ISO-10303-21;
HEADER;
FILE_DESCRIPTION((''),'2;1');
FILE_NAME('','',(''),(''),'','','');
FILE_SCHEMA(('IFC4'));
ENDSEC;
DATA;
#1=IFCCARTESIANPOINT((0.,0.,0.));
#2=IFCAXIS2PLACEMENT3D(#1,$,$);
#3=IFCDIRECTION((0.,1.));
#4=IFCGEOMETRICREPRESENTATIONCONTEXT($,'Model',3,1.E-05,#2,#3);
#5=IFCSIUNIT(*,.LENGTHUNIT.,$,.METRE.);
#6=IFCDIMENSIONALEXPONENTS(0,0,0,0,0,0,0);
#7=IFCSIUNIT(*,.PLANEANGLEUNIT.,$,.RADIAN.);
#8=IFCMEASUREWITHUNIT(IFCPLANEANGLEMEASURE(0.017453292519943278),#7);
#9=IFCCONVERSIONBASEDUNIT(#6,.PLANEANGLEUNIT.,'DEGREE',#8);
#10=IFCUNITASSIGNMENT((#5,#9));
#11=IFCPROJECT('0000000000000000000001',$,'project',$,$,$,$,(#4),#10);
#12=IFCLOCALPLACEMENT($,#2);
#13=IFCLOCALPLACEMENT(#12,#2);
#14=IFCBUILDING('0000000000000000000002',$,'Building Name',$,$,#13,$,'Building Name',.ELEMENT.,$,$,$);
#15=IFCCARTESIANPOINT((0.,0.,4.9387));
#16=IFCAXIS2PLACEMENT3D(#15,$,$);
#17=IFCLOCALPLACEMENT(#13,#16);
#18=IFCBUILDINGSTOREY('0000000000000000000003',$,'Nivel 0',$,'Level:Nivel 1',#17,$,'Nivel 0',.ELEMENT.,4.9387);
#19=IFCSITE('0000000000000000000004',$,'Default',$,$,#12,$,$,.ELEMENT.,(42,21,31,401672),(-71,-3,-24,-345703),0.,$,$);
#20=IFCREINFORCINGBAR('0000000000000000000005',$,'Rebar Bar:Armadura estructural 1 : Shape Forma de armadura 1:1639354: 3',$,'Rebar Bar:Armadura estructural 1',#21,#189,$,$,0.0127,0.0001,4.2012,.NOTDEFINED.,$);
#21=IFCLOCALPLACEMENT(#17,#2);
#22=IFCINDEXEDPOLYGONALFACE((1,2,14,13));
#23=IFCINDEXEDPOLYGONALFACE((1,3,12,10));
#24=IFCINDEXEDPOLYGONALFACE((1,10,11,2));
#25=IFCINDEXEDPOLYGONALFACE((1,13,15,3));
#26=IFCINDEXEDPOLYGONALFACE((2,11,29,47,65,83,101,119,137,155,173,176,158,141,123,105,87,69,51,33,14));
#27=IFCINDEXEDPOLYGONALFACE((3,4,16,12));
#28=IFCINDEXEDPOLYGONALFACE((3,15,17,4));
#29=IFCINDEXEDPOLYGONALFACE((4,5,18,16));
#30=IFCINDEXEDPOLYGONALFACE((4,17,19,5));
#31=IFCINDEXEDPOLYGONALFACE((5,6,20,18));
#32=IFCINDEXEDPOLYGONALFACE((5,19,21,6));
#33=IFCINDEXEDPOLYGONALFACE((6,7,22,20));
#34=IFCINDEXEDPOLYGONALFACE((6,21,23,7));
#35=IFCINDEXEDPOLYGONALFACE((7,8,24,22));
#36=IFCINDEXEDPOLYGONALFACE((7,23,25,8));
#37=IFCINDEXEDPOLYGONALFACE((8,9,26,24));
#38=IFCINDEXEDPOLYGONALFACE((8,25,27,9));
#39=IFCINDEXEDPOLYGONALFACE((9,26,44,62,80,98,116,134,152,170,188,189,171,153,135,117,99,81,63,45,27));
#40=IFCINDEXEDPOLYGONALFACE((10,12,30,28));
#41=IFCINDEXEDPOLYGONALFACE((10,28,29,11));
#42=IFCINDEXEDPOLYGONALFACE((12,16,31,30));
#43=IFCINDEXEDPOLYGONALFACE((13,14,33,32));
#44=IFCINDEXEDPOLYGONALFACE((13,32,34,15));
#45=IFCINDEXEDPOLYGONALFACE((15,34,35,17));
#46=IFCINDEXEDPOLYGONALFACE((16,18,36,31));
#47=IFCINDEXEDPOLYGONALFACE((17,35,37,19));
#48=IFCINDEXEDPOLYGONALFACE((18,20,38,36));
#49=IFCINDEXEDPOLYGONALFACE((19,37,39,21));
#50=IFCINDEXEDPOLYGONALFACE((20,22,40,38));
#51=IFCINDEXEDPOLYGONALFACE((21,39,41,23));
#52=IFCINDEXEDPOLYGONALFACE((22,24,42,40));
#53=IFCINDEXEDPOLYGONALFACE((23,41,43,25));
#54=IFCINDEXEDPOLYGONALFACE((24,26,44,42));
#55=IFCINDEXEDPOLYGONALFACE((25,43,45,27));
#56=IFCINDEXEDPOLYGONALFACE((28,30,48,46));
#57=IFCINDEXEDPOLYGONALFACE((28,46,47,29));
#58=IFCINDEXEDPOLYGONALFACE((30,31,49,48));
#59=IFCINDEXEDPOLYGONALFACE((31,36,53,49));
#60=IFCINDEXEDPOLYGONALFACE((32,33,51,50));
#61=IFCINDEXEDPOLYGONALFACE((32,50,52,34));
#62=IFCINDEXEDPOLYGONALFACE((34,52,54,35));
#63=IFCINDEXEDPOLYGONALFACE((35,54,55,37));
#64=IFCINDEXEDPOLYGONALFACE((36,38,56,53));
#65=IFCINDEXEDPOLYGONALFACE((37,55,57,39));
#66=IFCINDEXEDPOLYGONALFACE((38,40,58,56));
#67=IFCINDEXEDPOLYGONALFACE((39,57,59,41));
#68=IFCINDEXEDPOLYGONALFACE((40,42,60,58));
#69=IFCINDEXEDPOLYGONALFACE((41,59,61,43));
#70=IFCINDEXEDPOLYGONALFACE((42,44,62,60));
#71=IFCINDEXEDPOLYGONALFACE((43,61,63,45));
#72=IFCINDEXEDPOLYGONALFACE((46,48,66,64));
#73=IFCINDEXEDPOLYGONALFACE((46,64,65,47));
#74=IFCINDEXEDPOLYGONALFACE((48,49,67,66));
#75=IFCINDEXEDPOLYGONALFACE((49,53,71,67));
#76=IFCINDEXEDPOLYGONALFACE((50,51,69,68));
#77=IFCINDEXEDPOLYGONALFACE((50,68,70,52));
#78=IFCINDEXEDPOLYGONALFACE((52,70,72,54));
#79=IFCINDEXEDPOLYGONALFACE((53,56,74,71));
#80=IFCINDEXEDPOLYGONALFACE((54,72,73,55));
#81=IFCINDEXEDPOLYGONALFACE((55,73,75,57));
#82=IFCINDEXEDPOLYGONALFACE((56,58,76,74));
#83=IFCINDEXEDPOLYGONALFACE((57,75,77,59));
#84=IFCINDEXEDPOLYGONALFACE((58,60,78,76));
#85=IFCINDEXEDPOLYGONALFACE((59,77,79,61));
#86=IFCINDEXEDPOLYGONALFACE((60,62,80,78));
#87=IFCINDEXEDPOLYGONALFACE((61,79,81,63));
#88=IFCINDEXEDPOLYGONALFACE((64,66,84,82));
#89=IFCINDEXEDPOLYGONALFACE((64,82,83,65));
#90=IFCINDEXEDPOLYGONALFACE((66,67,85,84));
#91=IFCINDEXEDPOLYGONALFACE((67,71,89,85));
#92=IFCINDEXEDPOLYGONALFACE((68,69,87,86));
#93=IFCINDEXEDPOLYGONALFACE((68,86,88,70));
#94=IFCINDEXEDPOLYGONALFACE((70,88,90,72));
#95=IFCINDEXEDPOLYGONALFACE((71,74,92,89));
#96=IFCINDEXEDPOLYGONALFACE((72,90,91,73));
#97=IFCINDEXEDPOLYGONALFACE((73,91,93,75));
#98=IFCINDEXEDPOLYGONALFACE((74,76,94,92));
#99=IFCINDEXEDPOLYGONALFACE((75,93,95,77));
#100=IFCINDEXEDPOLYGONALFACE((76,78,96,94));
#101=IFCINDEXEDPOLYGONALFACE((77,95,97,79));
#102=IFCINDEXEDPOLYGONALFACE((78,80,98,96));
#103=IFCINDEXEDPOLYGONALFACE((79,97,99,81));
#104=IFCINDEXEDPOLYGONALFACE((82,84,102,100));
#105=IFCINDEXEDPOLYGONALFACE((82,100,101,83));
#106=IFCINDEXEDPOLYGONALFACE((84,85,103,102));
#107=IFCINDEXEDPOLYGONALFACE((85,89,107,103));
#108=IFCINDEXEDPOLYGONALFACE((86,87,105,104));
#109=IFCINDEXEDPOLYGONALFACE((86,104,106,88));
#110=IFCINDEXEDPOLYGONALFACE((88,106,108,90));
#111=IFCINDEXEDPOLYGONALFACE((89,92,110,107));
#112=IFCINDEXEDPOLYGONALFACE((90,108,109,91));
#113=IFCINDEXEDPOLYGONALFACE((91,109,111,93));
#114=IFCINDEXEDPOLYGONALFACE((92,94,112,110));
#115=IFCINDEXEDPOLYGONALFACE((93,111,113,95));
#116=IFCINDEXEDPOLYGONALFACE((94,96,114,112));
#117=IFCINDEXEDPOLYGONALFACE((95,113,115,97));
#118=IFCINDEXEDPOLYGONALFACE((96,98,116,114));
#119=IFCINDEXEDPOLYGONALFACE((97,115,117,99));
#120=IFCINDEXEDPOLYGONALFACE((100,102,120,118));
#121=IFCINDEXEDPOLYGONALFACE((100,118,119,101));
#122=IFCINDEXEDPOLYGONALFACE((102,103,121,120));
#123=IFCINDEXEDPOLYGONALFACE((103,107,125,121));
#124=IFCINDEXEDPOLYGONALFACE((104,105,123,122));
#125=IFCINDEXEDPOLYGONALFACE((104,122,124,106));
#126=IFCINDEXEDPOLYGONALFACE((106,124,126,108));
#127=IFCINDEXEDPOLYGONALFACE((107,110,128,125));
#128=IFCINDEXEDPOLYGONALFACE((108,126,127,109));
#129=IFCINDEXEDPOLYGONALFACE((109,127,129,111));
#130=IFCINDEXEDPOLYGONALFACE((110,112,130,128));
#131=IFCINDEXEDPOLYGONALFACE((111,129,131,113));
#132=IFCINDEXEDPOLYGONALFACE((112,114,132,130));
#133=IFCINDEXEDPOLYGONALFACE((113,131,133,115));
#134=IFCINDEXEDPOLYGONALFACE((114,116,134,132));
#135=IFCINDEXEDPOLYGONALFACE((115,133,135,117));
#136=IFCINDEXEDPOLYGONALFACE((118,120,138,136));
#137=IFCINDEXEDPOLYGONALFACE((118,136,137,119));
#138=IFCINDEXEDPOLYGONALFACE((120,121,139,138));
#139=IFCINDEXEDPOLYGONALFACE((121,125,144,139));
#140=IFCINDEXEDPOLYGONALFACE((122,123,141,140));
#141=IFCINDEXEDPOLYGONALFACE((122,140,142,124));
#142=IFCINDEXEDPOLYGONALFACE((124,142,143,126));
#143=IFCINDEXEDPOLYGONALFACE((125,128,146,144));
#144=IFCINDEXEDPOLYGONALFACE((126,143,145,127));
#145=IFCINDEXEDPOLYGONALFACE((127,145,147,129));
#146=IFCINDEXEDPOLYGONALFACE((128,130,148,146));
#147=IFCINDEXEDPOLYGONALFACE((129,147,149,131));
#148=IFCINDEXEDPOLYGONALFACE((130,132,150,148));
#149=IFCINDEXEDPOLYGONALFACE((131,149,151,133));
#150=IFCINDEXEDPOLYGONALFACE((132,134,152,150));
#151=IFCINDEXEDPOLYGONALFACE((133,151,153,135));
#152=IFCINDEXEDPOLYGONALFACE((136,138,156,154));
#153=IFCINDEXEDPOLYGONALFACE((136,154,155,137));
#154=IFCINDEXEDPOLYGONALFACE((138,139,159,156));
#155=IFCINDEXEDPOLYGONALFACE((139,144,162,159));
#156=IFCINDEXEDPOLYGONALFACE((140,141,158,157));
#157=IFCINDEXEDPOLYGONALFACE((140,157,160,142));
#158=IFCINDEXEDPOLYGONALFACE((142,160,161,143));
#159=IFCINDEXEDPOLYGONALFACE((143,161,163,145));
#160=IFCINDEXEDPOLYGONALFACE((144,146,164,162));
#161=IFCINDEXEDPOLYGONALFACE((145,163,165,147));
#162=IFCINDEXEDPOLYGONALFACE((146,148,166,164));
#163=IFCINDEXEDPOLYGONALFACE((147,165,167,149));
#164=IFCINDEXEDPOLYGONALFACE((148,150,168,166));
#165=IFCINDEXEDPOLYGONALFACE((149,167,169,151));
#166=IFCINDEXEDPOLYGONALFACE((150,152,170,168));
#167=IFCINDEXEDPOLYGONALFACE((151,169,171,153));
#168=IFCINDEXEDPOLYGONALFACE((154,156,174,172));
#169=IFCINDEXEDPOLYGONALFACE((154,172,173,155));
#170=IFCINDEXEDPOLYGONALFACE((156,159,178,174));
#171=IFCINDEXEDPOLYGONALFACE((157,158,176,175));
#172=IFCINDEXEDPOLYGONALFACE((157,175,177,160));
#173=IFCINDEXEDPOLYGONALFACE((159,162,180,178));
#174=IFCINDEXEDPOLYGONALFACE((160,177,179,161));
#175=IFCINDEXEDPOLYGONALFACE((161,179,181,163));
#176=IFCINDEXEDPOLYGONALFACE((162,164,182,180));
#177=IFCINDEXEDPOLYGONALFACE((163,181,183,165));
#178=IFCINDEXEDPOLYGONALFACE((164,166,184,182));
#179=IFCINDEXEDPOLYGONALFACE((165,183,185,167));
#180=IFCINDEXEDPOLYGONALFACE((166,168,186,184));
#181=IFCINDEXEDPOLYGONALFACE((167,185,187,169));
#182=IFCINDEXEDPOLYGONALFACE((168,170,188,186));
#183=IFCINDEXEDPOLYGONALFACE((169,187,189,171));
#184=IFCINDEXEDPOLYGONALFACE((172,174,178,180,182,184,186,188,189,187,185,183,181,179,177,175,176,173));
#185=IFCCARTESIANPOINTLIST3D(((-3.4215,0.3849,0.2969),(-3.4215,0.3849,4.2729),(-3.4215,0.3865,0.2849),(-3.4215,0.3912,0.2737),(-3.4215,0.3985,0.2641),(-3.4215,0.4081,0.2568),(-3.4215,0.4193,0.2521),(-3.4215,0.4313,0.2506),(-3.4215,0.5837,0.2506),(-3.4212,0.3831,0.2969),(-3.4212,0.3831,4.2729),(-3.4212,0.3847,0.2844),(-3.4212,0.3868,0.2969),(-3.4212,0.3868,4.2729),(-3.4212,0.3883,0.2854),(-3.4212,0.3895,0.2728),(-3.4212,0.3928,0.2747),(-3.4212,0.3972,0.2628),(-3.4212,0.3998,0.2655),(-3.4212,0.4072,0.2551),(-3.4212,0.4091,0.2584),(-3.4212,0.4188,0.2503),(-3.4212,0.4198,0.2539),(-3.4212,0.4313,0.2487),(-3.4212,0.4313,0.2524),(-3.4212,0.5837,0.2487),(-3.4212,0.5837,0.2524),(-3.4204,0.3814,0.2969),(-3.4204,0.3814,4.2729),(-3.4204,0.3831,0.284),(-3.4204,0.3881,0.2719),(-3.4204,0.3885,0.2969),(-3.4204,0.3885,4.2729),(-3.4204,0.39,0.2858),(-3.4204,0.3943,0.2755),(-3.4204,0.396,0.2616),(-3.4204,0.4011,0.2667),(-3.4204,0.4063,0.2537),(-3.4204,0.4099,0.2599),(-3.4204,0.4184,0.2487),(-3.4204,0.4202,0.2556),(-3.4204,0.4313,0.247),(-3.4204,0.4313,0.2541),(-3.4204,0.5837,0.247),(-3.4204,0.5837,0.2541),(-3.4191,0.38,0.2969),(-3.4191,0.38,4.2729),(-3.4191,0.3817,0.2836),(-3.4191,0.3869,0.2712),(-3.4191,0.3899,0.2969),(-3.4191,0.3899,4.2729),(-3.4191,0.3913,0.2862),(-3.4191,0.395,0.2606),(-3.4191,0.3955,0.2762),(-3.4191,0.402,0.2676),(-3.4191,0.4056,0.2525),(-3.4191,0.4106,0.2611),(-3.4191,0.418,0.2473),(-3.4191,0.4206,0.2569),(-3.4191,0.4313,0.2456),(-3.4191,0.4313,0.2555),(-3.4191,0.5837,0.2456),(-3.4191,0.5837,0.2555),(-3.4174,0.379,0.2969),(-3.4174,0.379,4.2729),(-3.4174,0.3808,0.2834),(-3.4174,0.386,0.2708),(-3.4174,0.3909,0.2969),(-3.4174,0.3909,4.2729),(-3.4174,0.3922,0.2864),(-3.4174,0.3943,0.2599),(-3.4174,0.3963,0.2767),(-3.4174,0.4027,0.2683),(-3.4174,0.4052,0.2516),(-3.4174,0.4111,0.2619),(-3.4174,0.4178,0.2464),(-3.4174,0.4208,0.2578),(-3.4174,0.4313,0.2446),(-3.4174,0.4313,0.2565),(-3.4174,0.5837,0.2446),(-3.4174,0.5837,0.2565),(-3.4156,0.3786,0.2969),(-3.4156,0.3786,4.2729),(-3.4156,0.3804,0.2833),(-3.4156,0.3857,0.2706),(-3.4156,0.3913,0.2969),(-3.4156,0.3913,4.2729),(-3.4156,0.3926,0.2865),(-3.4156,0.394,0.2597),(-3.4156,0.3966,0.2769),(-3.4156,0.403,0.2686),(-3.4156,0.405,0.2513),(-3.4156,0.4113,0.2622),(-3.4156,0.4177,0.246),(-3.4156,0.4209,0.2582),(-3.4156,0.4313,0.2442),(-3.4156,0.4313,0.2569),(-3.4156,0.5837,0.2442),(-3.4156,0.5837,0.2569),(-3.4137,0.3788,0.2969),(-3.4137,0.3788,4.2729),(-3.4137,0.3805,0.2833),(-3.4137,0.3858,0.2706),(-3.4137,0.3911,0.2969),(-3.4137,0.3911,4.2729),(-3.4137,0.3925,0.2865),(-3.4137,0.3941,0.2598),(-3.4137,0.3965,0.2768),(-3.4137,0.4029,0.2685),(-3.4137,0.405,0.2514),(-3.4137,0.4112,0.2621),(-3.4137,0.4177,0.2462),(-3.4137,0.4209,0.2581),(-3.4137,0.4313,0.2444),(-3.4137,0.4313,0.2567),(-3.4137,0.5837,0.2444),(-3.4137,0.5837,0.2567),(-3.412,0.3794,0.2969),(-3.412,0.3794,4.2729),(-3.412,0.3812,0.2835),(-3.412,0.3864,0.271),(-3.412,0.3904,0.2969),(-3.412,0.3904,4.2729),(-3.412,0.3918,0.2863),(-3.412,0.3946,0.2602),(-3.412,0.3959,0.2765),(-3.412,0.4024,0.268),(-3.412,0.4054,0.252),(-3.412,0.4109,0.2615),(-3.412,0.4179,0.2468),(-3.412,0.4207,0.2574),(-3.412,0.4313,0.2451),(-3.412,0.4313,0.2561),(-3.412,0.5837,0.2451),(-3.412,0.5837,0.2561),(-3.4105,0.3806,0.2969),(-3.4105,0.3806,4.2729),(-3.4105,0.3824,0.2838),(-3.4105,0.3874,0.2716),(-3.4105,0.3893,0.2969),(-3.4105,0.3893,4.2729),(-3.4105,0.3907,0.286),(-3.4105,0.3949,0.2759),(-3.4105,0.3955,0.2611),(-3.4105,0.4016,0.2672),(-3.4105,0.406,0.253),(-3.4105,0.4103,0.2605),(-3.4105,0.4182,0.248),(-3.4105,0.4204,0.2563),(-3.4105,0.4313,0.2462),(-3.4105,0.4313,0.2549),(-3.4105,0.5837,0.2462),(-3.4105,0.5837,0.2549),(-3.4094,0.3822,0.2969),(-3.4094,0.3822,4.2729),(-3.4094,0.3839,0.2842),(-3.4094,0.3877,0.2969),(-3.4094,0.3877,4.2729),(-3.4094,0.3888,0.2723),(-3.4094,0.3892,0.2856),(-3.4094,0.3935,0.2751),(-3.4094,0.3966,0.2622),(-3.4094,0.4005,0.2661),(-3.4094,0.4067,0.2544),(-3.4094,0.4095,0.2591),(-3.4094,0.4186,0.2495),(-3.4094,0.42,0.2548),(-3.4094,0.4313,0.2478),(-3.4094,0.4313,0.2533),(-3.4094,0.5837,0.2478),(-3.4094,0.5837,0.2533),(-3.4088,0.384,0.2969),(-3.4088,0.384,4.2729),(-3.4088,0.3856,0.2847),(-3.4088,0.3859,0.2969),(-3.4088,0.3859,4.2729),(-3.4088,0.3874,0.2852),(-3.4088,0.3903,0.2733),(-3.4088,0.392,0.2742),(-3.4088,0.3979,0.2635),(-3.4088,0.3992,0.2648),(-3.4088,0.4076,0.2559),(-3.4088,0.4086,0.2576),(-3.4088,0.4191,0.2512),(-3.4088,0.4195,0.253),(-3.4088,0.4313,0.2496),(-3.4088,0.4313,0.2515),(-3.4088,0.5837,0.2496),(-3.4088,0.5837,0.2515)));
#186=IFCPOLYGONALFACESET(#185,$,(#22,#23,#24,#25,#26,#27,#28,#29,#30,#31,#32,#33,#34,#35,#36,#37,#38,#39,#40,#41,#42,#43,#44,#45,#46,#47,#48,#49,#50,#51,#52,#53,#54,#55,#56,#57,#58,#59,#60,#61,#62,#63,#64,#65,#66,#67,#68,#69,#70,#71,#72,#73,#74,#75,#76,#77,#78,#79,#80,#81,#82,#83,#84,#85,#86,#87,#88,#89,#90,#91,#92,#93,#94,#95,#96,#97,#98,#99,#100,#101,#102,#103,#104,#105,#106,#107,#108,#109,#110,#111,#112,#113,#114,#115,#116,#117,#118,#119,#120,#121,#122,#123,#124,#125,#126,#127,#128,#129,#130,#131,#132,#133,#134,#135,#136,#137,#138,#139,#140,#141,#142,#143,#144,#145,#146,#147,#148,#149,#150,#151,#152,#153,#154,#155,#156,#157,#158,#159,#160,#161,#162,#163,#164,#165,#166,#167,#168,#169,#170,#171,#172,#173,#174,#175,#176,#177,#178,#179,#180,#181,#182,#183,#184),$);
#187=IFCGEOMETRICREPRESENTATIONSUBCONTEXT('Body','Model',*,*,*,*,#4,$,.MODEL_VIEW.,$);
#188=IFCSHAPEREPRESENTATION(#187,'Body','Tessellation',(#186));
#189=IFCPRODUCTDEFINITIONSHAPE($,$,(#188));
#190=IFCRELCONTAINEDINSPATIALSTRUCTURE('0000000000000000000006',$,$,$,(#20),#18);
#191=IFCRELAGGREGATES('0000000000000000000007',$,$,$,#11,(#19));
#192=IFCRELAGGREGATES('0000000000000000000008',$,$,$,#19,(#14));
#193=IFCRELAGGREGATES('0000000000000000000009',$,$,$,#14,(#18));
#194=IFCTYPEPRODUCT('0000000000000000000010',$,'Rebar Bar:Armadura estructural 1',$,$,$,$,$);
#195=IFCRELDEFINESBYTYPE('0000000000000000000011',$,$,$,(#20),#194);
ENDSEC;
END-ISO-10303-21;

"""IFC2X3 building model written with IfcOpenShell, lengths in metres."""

from ifc_helpers import new_model, entity, si_unit, converted_unit, direction, frame, origin, place, context, subcontext, project, spatial, type_object, element, save


model = new_model("IFC2X3")

# Units and contexts
model_context = context("Model", 3, precision=1e-05, world=origin(), true_north=direction((0.0, 1.0)))
body_context = subcontext(model_context, "Body", "Model", "MODEL_VIEW")
ifc_project = project(units=[si_unit("LENGTHUNIT", "METRE"), converted_unit("PLANEANGLEUNIT", "DEGREE", entity("IfcPlaneAngleMeasure", 0.017453292519943278), si_unit("PLANEANGLEUNIT", "RADIAN"), dimensions=[0, 0, 0, 0, 0, 0, 0])], contexts=[model_context])

# Site, building, storey
site_placement = place(None, origin())
site = spatial("IfcSite", under=ifc_project, at=site_placement, Name="Default", CompositionType="ELEMENT", RefLatitude=(42, 21, 31, 401672), RefLongitude=(-71, -3, -24, -345703), RefElevation=0.0)
building_placement = place(site_placement, origin())
building = spatial("IfcBuilding", under=site, at=building_placement, Name="Building Name", LongName="Building Name", CompositionType="ELEMENT")
storey_placement = place(building_placement, frame((0.0, 0.0, 4.9387)))
storey = spatial("IfcBuildingStorey", under=building, at=storey_placement, Name="Nivel 0", ObjectType="Level:Nivel 1", LongName="Nivel 0", CompositionType="ELEMENT", Elevation=4.9387)

# Reinforcing bar
type_product = type_object("IfcTypeProduct", Name="Rebar Bar:Armadura estructural 1")
reinforcing_bar_1_placement = place(storey_placement, origin())
element("IfcReinforcingBar", 1, at=reinforcing_bar_1_placement, inside=storey, type_object=type_product, Name="Rebar Bar:Armadura estructural 1 : Shape Forma de armadura 1:1639354: 3", ObjectType="Rebar Bar:Armadura estructural 1", BarLength=4.2012, BarRole="NOTDEFINED", CrossSectionArea=0.0001, NominalDiameter=0.0127, context=body_context, shape_type="AdvancedSweptSolid", body=[
    entity("IfcSweptDiskSolid", entity("IfcCompositeCurve", [entity("IfcCompositeCurveSegment", "CONTINUOUS", True, entity("IfcPolyline", [entity("IfcCartesianPoint", [-3.4151, 0.5837, 0.2506]), entity("IfcCartesianPoint", [-3.4151, 0.4313, 0.2506])])), entity("IfcCompositeCurveSegment", "CONTINUOUS", True, entity("IfcTrimmedCurve", entity("IfcCircle", entity("IfcAxis2Placement3D", entity("IfcCartesianPoint", [-3.4151, 0.4313, 0.2969]), entity("IfcDirection", [-1.0, 0.0, 0.0]), entity("IfcDirection", [0.0, -1.0, 0.0])), 0.0464), [entity("IfcParameterValue", 270.0)], [entity("IfcParameterValue", 360.0)], True, "PARAMETER")), entity("IfcCompositeCurveSegment", "CONTINUOUS", True, entity("IfcPolyline", [entity("IfcCartesianPoint", [-3.4151, 0.3849, 0.2969]), entity("IfcCartesianPoint", [-3.4151, 0.3849, 4.2729])]))], False), 0.0063, None, 0.0, 92.0),
])

save(model, "model.ifc")
